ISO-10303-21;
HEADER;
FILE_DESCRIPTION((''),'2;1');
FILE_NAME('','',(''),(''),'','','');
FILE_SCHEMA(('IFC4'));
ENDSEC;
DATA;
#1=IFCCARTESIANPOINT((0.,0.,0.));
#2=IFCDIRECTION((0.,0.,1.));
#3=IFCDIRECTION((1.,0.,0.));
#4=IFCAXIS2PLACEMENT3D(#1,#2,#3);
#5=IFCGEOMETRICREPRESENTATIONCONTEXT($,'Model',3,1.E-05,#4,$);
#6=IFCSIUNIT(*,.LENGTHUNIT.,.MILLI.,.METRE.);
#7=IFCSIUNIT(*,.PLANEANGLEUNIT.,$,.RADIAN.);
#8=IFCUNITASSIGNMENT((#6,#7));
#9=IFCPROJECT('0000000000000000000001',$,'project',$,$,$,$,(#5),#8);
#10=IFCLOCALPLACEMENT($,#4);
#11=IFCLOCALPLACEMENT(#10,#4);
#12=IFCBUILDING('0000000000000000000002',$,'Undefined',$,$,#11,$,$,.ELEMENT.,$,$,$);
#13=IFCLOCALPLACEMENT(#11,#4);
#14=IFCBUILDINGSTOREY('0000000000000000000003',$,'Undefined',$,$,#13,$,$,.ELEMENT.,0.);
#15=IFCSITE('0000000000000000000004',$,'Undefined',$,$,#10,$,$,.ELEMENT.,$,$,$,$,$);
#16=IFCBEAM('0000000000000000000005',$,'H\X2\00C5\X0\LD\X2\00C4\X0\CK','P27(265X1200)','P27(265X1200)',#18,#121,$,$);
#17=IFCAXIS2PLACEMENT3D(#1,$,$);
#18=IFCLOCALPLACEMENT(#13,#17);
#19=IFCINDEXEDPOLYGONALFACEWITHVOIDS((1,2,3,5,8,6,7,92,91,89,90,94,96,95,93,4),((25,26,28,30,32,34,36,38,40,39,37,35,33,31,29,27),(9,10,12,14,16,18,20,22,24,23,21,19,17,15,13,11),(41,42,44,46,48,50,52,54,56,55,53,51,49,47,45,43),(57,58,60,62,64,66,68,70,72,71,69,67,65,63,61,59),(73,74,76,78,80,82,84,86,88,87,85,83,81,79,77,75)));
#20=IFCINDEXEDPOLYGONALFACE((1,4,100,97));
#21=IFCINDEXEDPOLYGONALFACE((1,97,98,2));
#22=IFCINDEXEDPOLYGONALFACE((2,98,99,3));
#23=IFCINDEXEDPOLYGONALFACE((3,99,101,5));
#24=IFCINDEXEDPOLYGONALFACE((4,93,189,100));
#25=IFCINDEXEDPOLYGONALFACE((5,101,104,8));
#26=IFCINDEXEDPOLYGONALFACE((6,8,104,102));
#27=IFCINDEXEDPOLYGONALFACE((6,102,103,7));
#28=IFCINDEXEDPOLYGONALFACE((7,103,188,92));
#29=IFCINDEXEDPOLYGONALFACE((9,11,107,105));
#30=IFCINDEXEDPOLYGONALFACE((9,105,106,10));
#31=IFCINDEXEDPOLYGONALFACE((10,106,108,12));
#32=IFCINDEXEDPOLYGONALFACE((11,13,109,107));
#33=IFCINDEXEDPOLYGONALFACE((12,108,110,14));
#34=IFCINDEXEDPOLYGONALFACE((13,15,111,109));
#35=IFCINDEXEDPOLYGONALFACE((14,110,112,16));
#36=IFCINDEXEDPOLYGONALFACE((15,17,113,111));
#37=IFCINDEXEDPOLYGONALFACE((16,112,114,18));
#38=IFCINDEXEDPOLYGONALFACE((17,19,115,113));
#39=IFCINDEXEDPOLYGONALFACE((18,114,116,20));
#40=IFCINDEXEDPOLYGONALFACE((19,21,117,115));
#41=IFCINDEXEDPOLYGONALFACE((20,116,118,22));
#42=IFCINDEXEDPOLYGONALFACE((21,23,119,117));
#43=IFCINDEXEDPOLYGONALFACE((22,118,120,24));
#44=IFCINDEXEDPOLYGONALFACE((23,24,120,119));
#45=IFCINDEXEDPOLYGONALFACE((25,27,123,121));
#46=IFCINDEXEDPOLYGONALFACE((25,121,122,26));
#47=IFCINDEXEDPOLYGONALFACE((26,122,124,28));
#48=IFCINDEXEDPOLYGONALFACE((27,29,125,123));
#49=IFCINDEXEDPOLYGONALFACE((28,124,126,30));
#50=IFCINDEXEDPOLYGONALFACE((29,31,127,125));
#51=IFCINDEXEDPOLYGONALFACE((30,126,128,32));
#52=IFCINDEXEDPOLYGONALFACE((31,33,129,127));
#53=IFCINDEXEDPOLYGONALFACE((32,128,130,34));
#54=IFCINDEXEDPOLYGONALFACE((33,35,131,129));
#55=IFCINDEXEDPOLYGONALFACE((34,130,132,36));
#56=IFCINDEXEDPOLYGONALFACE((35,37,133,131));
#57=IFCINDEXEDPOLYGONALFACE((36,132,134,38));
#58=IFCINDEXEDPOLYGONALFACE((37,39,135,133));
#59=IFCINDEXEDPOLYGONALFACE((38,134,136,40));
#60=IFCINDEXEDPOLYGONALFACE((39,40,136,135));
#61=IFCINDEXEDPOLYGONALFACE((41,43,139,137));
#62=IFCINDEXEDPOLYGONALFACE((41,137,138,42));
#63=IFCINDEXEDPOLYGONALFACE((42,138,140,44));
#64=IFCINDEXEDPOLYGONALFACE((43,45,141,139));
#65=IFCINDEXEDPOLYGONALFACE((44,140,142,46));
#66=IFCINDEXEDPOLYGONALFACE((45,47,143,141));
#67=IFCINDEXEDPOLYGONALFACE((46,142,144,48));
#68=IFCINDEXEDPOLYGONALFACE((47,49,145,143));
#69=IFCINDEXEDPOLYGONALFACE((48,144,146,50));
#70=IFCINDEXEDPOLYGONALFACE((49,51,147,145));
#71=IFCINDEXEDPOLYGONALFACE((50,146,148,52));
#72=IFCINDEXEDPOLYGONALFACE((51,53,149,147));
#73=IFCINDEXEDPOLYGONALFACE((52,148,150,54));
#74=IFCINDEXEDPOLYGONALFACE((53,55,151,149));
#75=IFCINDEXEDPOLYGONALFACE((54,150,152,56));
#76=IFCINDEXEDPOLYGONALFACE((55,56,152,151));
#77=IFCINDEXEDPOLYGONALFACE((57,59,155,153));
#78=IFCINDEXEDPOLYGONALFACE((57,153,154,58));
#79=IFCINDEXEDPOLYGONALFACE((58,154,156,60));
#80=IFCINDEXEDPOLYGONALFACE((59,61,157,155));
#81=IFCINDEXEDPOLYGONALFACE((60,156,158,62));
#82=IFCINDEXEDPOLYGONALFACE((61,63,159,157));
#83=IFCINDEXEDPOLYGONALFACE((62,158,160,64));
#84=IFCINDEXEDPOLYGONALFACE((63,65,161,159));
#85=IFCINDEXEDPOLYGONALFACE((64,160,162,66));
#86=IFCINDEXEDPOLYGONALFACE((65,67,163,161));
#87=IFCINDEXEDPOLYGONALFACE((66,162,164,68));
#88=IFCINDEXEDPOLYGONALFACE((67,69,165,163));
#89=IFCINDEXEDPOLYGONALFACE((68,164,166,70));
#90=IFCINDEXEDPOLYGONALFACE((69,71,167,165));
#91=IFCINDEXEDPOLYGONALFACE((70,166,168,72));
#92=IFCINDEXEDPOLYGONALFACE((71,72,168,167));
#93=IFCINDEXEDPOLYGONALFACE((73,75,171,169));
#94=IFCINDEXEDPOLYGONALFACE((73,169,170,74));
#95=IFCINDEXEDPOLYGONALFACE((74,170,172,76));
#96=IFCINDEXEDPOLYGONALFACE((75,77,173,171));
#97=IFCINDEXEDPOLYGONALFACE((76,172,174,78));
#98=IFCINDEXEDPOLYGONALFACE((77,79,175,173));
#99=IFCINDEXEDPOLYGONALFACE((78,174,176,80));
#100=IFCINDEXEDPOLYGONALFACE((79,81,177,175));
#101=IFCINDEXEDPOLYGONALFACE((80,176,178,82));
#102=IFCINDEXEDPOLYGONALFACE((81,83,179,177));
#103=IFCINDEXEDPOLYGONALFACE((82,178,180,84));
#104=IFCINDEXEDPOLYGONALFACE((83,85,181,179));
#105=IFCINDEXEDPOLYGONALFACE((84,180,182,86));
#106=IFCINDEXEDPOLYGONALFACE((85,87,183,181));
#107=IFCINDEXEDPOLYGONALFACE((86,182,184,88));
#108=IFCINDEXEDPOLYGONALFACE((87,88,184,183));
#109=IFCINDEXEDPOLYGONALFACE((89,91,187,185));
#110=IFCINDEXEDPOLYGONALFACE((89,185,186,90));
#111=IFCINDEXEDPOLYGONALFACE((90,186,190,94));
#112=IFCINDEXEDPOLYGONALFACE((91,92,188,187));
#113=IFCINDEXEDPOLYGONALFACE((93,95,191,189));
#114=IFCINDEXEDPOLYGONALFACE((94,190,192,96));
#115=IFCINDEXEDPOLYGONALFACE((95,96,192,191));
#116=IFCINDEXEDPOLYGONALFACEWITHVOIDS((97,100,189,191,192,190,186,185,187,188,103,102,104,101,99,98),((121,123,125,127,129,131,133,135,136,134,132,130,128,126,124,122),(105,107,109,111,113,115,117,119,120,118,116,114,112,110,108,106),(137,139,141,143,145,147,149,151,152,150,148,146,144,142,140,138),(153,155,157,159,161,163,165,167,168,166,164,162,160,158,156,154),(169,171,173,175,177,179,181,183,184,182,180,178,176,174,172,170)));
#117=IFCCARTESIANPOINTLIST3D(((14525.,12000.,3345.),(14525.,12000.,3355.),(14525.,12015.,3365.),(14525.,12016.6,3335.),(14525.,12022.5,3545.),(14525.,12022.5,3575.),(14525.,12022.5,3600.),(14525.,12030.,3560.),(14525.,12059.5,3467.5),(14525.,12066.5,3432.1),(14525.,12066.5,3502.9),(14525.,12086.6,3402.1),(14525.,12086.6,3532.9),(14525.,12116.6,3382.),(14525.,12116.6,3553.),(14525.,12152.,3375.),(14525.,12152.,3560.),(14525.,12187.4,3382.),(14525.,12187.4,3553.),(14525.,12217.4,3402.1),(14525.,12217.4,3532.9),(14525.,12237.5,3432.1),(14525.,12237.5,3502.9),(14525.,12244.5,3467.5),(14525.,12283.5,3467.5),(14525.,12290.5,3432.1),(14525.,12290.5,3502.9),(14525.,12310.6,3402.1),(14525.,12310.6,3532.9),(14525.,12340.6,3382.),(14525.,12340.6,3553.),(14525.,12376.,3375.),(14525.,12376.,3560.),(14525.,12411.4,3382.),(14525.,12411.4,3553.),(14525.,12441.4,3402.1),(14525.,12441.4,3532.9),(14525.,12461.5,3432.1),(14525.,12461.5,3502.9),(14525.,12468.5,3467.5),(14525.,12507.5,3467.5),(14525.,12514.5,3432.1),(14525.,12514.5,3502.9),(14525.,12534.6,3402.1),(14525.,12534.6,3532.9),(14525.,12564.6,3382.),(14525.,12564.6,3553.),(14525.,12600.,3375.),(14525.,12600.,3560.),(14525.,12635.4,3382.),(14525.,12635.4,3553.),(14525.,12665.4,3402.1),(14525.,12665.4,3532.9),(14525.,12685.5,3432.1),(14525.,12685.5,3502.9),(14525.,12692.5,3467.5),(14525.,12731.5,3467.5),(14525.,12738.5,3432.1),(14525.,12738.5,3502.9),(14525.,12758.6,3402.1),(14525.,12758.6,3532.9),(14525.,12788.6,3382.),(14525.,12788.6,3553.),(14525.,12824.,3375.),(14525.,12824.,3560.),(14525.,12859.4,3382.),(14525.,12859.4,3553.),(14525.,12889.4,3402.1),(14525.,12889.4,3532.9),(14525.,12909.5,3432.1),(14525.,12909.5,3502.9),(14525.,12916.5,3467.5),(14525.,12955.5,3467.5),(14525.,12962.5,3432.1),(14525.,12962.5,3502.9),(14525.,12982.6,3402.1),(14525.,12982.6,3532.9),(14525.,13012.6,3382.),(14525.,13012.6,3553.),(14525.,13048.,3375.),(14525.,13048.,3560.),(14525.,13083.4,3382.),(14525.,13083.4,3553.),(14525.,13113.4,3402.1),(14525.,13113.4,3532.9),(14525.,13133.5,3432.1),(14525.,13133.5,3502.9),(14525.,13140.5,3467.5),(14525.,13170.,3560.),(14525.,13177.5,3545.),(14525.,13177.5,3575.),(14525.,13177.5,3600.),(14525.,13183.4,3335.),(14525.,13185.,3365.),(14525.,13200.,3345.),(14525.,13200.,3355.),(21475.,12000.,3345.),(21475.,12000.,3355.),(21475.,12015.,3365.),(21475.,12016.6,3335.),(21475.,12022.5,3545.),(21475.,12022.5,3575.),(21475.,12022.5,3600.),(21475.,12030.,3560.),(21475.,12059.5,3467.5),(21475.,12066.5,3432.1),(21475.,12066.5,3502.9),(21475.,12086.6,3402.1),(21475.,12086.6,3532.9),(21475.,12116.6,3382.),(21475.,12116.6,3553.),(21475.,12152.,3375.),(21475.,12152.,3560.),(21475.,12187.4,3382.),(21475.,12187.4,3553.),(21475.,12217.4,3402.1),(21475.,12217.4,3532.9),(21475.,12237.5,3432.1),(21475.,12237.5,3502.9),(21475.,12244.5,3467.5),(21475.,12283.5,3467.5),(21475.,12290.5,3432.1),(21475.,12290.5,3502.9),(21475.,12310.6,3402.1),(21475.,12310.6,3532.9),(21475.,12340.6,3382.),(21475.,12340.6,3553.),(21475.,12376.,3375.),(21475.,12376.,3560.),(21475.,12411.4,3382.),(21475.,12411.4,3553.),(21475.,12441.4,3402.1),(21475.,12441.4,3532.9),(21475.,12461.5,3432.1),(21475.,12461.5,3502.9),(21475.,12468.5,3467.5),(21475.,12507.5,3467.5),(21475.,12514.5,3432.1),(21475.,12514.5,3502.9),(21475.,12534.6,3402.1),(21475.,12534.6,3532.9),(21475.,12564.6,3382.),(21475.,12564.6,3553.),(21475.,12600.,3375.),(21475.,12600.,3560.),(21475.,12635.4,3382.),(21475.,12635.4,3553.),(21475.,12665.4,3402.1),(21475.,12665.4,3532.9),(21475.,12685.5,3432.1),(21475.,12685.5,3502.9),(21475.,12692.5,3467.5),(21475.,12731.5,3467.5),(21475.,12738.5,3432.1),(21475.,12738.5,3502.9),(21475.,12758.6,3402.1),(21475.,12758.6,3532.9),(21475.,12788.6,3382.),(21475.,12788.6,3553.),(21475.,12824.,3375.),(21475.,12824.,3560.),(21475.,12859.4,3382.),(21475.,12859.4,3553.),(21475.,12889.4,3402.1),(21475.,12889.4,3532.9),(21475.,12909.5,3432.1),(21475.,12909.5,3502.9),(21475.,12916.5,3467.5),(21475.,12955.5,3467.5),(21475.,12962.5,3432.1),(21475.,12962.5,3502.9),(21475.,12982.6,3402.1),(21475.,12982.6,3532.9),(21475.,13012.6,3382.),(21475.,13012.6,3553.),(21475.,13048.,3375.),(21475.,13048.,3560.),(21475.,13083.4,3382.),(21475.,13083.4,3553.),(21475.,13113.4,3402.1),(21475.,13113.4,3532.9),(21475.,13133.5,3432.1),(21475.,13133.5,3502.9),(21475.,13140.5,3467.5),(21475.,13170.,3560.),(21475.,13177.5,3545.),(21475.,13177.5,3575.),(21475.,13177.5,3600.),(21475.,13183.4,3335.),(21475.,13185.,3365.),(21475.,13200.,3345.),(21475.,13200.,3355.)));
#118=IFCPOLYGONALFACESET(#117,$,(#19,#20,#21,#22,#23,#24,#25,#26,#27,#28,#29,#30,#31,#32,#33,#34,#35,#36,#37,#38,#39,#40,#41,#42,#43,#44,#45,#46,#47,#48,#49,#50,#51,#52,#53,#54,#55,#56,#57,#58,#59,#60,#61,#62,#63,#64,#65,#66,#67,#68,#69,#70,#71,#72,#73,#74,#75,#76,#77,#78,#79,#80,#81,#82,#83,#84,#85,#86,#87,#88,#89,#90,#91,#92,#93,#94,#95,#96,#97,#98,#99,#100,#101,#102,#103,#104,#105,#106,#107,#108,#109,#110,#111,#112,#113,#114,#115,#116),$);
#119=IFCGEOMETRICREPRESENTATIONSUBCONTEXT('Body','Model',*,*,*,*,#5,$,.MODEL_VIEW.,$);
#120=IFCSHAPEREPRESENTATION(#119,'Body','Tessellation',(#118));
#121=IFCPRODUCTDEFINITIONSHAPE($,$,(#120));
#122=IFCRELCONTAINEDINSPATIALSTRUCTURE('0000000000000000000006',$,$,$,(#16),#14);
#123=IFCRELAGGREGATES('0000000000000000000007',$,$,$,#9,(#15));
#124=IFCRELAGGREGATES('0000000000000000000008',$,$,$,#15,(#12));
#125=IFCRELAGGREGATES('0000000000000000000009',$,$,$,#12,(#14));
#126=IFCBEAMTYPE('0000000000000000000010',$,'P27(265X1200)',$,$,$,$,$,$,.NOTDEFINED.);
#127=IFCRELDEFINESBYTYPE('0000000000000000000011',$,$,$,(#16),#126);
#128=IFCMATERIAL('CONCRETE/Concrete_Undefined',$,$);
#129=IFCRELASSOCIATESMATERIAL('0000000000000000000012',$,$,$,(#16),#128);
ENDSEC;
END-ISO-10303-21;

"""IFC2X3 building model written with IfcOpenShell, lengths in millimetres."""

from ifc_helpers import new_model, si_unit, frame, origin_with_axes, place, context, subcontext, project, spatial, polyline, outline, extrude, material, type_object, element, save


model = new_model("IFC2X3")

# Units and contexts
model_context = context("Model", 3, precision=1e-05, world=origin_with_axes())
body_context = subcontext(model_context, "Body", "Model", "MODEL_VIEW")
ifc_project = project(units=[si_unit("LENGTHUNIT", "METRE", prefix="MILLI"), si_unit("PLANEANGLEUNIT", "RADIAN")], contexts=[model_context])

# Site, building, storey
site_placement = place(None, origin_with_axes())
site = spatial("IfcSite", under=ifc_project, at=site_placement, Name="Undefined", CompositionType="ELEMENT")
building_placement = place(site_placement, origin_with_axes())
building = spatial("IfcBuilding", under=site, at=building_placement, Name="Undefined", CompositionType="ELEMENT")
storey_placement = place(building_placement, origin_with_axes())
storey = spatial("IfcBuildingStorey", under=building, at=storey_placement, Name="Undefined", CompositionType="ELEMENT", Elevation=0.0)

# Beam
ifc_material_1 = material(Name="CONCRETE/Concrete_Undefined")
beam_type_1 = type_object("IfcBeamType", Name="P27(265X1200)", PredefinedType="NOTDEFINED")
beam_1_placement = place(storey_placement, frame((14525.0, 12600.0, 3467.5), z_axis=(0.0, 0.0, 1.0), x_axis=(1.0, 0.0, 0.0)))
element("IfcBeam", 1, at=beam_1_placement, inside=storey, type_object=beam_type_1, material=ifc_material_1, Name="HÅLDÄCK", Description="P27(265X1200)", ObjectType="P27(265X1200)", context=body_context, shape_type="SweptSolid", body=[
    extrude(outline(polyline([(-583.4, -132.5), (-600.0, -122.5), (-600.0, -112.5), (-585.0, -102.5), (-577.5, 77.5), (-570.0, 92.5), (-577.5, 107.5), (-577.5, 132.5), (577.5, 132.5), (577.5, 107.5), (570.0, 92.5), (577.5, 77.5), (585.0, -102.5), (600.0, -112.5), (600.0, -122.5), (583.4, -132.5), (-583.4, -132.5)]), holes=[polyline([(-513.4, 65.4), (-533.5, 35.4), (-540.5, 0.0), (-533.5, -35.4), (-513.4, -65.4), (-483.4, -85.5), (-448.0, -92.5), (-412.6, -85.5), (-382.6, -65.4), (-362.5, -35.4), (-355.5, 0.0), (-362.5, 35.4), (-382.6, 65.4), (-412.6, 85.5), (-448.0, 92.5), (-483.4, 85.5), (-513.4, 65.4)]), polyline([(-289.4, 65.4), (-309.5, 35.4), (-316.5, 0.0), (-309.5, -35.4), (-289.4, -65.4), (-259.4, -85.5), (-224.0, -92.5), (-188.6, -85.5), (-158.6, -65.4), (-138.5, -35.4), (-131.5, 0.0), (-138.5, 35.4), (-158.6, 65.4), (-188.6, 85.5), (-224.0, 92.5), (-259.4, 85.5), (-289.4, 65.4)]), polyline([(-65.4, 65.4), (-85.5, 35.4), (-92.5, 0.0), (-85.5, -35.4), (-65.4, -65.4), (-35.4, -85.5), (0.0, -92.5), (35.4, -85.5), (65.4, -65.4), (85.5, -35.4), (92.5, 0.0), (85.5, 35.4), (65.4, 65.4), (35.4, 85.5), (0.0, 92.5), (-35.4, 85.5), (-65.4, 65.4)]), polyline([(158.6, 65.4), (138.5, 35.4), (131.5, 0.0), (138.5, -35.4), (158.6, -65.4), (188.6, -85.5), (224.0, -92.5), (259.4, -85.5), (289.4, -65.4), (309.5, -35.4), (316.5, 0.0), (309.5, 35.4), (289.4, 65.4), (259.4, 85.5), (224.0, 92.5), (188.6, 85.5), (158.6, 65.4)]), polyline([(382.6, 65.4), (362.5, 35.4), (355.5, 0.0), (362.5, -35.4), (382.6, -65.4), (412.6, -85.5), (448.0, -92.5), (483.4, -85.5), (513.4, -65.4), (533.5, -35.4), (540.5, 0.0), (533.5, 35.4), (513.4, 65.4), (483.4, 85.5), (448.0, 92.5), (412.6, 85.5), (382.6, 65.4)])]), frame((6950.0, 0.0, 0.0), z_axis=(-1.0, 0.0, 0.0), x_axis=(0.0, -1.0, 0.0)), (0.0, 0.0, 1.0), 6950.0),
])

save(model, "model.ifc")
